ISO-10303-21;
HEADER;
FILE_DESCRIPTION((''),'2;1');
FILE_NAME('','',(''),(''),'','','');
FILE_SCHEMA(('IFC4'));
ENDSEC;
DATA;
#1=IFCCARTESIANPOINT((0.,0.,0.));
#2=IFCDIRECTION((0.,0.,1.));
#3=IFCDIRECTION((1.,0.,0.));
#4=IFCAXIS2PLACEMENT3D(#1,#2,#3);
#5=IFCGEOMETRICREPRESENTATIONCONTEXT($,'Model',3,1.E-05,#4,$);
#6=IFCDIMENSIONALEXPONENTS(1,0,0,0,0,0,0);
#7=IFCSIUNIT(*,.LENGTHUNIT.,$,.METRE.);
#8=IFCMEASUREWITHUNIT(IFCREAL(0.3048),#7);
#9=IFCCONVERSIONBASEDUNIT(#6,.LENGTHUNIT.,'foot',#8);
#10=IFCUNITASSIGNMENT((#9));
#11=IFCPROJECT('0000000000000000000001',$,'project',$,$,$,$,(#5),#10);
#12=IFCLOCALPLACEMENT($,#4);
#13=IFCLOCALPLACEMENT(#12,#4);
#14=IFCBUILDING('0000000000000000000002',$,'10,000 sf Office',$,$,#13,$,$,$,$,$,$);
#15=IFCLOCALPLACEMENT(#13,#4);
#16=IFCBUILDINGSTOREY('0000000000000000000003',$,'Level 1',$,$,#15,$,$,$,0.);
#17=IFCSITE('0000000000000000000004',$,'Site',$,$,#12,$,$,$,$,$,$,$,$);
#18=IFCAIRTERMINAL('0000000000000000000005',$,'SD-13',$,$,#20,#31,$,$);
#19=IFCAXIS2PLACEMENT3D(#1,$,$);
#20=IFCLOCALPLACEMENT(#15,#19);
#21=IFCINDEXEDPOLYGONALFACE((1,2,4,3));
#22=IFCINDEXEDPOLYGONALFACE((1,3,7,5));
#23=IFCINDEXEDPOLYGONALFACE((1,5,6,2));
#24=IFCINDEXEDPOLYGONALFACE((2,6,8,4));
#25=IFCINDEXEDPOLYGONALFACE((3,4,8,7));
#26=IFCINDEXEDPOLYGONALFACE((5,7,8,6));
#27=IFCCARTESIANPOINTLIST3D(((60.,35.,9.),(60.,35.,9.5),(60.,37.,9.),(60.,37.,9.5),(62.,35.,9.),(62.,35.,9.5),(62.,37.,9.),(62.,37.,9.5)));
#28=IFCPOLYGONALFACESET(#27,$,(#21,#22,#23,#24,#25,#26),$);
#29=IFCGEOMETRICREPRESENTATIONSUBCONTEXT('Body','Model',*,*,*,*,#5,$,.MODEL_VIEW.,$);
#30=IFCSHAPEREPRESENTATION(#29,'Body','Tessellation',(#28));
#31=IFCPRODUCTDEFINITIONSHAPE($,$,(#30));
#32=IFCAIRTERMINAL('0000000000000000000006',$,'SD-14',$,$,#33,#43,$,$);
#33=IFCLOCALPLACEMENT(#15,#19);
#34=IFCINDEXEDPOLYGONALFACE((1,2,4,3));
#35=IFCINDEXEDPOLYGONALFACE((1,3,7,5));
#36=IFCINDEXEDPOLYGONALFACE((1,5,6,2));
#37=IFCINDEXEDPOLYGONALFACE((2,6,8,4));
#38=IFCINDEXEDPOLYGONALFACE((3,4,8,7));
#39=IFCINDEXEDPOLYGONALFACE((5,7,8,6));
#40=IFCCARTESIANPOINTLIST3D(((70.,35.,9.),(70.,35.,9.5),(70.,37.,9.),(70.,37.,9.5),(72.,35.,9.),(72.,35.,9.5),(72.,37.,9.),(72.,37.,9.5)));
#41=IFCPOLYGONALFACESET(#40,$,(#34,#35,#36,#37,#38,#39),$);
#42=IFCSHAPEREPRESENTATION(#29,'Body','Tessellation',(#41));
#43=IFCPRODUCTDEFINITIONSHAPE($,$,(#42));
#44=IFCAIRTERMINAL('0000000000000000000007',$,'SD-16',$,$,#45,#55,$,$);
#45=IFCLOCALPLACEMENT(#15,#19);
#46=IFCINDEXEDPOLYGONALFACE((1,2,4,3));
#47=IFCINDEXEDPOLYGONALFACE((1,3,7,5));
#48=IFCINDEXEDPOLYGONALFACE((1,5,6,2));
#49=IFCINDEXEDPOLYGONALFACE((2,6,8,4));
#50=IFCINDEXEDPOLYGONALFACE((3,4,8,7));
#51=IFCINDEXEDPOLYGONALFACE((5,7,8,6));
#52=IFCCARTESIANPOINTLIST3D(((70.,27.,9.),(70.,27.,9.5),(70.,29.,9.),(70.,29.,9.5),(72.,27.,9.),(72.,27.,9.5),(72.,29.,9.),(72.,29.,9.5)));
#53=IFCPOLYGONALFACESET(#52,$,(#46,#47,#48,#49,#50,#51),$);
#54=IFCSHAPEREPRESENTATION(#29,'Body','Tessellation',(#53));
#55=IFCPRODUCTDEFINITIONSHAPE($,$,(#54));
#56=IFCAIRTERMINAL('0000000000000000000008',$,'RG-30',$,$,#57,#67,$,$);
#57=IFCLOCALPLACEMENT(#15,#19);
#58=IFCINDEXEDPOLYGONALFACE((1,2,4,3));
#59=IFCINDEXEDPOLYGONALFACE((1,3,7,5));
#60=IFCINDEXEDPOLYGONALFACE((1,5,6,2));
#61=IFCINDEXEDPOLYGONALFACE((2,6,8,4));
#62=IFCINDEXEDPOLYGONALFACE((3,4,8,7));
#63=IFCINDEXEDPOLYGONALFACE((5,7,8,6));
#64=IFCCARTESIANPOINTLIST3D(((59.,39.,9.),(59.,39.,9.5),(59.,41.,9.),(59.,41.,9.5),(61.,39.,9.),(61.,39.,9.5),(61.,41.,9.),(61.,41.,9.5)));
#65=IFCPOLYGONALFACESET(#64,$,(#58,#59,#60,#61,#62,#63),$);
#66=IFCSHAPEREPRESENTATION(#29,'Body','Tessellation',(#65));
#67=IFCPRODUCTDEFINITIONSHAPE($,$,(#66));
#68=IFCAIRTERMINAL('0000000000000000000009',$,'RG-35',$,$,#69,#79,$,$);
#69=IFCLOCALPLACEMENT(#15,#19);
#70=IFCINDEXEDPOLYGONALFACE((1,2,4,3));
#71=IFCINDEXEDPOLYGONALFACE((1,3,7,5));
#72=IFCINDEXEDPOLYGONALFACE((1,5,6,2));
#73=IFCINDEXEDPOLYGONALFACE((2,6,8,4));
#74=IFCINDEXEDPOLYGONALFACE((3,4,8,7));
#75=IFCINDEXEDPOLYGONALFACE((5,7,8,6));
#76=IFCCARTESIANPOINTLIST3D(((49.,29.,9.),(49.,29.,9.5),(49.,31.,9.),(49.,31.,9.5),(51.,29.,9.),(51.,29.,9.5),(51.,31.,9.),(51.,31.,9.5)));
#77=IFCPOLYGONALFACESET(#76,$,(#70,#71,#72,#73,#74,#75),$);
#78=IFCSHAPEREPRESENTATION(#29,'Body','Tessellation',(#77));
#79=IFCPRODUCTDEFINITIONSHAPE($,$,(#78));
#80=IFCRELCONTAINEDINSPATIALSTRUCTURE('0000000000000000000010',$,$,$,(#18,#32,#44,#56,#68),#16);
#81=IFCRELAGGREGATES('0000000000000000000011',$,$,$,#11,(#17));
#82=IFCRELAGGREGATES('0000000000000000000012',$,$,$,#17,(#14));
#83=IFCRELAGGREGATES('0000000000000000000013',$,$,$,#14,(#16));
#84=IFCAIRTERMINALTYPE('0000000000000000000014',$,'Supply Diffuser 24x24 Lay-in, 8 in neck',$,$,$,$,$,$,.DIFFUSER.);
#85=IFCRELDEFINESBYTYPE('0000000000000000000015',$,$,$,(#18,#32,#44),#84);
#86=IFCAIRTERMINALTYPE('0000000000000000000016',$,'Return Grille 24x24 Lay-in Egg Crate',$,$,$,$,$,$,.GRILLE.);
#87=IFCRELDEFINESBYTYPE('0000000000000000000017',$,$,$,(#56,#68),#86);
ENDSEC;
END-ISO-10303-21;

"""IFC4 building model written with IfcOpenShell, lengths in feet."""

from ifc_helpers import new_model, entity, si_unit, converted_unit, frame, origin_with_axes, place, context, subcontext, project, spatial, rectangle, extrude, type_object, element, save


model = new_model("IFC4")

# Units and contexts
model_context = context("Model", 3, precision=1e-05, world=origin_with_axes())
body_context = subcontext(model_context, "Body", "Model", "MODEL_VIEW")
ifc_project = project(units=[converted_unit("LENGTHUNIT", "foot", entity("IfcReal", 0.3048), si_unit("LENGTHUNIT", "METRE"), dimensions=[1, 0, 0, 0, 0, 0, 0])], contexts=[model_context])

# Site, building, storey
site_placement = place(None, origin_with_axes())
site = spatial("IfcSite", under=ifc_project, at=site_placement, Name="Site")
building_placement = place(site_placement, origin_with_axes())
building = spatial("IfcBuilding", under=site, at=building_placement, Name="10,000 sf Office")
storey_placement = place(building_placement, origin_with_axes())
storey = spatial("IfcBuildingStorey", under=building, at=storey_placement, Name="Level 1", Elevation=0.0)

# Air terminals
air_terminal_type_1 = type_object("IfcAirTerminalType", Name="Supply Diffuser 24x24 Lay-in, 8 in neck", PredefinedType="DIFFUSER")
for number, where, z_axis, x_axis, name in (
    (1, (61.0, 36.0, 9.0), (0.0, 0.0, 1.0), (1.0, 0.0, 0.0), "SD-13"),
    (2, (71.0, 36.0, 9.0), (0.0, 0.0, 1.0), (1.0, 0.0, 0.0), "SD-14"),
    (3, (71.0, 28.0, 9.0), (0.0, 0.0, 1.0), (1.0, 0.0, 0.0), "SD-16"),
):
    element("IfcAirTerminal", number, at=place(storey_placement, frame(where, z_axis=z_axis, x_axis=x_axis)), inside=storey, type_object=air_terminal_type_1, Name=name, context=body_context, shape_type="SweptSolid", body=[
        extrude(rectangle(XDim=2.0, YDim=2.0), None, (0.0, 0.0, 1.0), 0.5),
    ])
air_terminal_type_2 = type_object("IfcAirTerminalType", Name="Return Grille 24x24 Lay-in Egg Crate", PredefinedType="GRILLE")
for number, where, z_axis, x_axis, name in (
    (4, (60.0, 40.0, 9.0), (0.0, 0.0, 1.0), (1.0, 0.0, 0.0), "RG-30"),
    (5, (50.0, 30.0, 9.0), (0.0, 0.0, 1.0), (1.0, 0.0, 0.0), "RG-35"),
):
    element("IfcAirTerminal", number, at=place(storey_placement, frame(where, z_axis=z_axis, x_axis=x_axis)), inside=storey, type_object=air_terminal_type_2, Name=name, context=body_context, shape_type="SweptSolid", body=[
        extrude(rectangle(XDim=2.0, YDim=2.0), None, (0.0, 0.0, 1.0), 0.5),
    ])

save(model, "model.ifc")
